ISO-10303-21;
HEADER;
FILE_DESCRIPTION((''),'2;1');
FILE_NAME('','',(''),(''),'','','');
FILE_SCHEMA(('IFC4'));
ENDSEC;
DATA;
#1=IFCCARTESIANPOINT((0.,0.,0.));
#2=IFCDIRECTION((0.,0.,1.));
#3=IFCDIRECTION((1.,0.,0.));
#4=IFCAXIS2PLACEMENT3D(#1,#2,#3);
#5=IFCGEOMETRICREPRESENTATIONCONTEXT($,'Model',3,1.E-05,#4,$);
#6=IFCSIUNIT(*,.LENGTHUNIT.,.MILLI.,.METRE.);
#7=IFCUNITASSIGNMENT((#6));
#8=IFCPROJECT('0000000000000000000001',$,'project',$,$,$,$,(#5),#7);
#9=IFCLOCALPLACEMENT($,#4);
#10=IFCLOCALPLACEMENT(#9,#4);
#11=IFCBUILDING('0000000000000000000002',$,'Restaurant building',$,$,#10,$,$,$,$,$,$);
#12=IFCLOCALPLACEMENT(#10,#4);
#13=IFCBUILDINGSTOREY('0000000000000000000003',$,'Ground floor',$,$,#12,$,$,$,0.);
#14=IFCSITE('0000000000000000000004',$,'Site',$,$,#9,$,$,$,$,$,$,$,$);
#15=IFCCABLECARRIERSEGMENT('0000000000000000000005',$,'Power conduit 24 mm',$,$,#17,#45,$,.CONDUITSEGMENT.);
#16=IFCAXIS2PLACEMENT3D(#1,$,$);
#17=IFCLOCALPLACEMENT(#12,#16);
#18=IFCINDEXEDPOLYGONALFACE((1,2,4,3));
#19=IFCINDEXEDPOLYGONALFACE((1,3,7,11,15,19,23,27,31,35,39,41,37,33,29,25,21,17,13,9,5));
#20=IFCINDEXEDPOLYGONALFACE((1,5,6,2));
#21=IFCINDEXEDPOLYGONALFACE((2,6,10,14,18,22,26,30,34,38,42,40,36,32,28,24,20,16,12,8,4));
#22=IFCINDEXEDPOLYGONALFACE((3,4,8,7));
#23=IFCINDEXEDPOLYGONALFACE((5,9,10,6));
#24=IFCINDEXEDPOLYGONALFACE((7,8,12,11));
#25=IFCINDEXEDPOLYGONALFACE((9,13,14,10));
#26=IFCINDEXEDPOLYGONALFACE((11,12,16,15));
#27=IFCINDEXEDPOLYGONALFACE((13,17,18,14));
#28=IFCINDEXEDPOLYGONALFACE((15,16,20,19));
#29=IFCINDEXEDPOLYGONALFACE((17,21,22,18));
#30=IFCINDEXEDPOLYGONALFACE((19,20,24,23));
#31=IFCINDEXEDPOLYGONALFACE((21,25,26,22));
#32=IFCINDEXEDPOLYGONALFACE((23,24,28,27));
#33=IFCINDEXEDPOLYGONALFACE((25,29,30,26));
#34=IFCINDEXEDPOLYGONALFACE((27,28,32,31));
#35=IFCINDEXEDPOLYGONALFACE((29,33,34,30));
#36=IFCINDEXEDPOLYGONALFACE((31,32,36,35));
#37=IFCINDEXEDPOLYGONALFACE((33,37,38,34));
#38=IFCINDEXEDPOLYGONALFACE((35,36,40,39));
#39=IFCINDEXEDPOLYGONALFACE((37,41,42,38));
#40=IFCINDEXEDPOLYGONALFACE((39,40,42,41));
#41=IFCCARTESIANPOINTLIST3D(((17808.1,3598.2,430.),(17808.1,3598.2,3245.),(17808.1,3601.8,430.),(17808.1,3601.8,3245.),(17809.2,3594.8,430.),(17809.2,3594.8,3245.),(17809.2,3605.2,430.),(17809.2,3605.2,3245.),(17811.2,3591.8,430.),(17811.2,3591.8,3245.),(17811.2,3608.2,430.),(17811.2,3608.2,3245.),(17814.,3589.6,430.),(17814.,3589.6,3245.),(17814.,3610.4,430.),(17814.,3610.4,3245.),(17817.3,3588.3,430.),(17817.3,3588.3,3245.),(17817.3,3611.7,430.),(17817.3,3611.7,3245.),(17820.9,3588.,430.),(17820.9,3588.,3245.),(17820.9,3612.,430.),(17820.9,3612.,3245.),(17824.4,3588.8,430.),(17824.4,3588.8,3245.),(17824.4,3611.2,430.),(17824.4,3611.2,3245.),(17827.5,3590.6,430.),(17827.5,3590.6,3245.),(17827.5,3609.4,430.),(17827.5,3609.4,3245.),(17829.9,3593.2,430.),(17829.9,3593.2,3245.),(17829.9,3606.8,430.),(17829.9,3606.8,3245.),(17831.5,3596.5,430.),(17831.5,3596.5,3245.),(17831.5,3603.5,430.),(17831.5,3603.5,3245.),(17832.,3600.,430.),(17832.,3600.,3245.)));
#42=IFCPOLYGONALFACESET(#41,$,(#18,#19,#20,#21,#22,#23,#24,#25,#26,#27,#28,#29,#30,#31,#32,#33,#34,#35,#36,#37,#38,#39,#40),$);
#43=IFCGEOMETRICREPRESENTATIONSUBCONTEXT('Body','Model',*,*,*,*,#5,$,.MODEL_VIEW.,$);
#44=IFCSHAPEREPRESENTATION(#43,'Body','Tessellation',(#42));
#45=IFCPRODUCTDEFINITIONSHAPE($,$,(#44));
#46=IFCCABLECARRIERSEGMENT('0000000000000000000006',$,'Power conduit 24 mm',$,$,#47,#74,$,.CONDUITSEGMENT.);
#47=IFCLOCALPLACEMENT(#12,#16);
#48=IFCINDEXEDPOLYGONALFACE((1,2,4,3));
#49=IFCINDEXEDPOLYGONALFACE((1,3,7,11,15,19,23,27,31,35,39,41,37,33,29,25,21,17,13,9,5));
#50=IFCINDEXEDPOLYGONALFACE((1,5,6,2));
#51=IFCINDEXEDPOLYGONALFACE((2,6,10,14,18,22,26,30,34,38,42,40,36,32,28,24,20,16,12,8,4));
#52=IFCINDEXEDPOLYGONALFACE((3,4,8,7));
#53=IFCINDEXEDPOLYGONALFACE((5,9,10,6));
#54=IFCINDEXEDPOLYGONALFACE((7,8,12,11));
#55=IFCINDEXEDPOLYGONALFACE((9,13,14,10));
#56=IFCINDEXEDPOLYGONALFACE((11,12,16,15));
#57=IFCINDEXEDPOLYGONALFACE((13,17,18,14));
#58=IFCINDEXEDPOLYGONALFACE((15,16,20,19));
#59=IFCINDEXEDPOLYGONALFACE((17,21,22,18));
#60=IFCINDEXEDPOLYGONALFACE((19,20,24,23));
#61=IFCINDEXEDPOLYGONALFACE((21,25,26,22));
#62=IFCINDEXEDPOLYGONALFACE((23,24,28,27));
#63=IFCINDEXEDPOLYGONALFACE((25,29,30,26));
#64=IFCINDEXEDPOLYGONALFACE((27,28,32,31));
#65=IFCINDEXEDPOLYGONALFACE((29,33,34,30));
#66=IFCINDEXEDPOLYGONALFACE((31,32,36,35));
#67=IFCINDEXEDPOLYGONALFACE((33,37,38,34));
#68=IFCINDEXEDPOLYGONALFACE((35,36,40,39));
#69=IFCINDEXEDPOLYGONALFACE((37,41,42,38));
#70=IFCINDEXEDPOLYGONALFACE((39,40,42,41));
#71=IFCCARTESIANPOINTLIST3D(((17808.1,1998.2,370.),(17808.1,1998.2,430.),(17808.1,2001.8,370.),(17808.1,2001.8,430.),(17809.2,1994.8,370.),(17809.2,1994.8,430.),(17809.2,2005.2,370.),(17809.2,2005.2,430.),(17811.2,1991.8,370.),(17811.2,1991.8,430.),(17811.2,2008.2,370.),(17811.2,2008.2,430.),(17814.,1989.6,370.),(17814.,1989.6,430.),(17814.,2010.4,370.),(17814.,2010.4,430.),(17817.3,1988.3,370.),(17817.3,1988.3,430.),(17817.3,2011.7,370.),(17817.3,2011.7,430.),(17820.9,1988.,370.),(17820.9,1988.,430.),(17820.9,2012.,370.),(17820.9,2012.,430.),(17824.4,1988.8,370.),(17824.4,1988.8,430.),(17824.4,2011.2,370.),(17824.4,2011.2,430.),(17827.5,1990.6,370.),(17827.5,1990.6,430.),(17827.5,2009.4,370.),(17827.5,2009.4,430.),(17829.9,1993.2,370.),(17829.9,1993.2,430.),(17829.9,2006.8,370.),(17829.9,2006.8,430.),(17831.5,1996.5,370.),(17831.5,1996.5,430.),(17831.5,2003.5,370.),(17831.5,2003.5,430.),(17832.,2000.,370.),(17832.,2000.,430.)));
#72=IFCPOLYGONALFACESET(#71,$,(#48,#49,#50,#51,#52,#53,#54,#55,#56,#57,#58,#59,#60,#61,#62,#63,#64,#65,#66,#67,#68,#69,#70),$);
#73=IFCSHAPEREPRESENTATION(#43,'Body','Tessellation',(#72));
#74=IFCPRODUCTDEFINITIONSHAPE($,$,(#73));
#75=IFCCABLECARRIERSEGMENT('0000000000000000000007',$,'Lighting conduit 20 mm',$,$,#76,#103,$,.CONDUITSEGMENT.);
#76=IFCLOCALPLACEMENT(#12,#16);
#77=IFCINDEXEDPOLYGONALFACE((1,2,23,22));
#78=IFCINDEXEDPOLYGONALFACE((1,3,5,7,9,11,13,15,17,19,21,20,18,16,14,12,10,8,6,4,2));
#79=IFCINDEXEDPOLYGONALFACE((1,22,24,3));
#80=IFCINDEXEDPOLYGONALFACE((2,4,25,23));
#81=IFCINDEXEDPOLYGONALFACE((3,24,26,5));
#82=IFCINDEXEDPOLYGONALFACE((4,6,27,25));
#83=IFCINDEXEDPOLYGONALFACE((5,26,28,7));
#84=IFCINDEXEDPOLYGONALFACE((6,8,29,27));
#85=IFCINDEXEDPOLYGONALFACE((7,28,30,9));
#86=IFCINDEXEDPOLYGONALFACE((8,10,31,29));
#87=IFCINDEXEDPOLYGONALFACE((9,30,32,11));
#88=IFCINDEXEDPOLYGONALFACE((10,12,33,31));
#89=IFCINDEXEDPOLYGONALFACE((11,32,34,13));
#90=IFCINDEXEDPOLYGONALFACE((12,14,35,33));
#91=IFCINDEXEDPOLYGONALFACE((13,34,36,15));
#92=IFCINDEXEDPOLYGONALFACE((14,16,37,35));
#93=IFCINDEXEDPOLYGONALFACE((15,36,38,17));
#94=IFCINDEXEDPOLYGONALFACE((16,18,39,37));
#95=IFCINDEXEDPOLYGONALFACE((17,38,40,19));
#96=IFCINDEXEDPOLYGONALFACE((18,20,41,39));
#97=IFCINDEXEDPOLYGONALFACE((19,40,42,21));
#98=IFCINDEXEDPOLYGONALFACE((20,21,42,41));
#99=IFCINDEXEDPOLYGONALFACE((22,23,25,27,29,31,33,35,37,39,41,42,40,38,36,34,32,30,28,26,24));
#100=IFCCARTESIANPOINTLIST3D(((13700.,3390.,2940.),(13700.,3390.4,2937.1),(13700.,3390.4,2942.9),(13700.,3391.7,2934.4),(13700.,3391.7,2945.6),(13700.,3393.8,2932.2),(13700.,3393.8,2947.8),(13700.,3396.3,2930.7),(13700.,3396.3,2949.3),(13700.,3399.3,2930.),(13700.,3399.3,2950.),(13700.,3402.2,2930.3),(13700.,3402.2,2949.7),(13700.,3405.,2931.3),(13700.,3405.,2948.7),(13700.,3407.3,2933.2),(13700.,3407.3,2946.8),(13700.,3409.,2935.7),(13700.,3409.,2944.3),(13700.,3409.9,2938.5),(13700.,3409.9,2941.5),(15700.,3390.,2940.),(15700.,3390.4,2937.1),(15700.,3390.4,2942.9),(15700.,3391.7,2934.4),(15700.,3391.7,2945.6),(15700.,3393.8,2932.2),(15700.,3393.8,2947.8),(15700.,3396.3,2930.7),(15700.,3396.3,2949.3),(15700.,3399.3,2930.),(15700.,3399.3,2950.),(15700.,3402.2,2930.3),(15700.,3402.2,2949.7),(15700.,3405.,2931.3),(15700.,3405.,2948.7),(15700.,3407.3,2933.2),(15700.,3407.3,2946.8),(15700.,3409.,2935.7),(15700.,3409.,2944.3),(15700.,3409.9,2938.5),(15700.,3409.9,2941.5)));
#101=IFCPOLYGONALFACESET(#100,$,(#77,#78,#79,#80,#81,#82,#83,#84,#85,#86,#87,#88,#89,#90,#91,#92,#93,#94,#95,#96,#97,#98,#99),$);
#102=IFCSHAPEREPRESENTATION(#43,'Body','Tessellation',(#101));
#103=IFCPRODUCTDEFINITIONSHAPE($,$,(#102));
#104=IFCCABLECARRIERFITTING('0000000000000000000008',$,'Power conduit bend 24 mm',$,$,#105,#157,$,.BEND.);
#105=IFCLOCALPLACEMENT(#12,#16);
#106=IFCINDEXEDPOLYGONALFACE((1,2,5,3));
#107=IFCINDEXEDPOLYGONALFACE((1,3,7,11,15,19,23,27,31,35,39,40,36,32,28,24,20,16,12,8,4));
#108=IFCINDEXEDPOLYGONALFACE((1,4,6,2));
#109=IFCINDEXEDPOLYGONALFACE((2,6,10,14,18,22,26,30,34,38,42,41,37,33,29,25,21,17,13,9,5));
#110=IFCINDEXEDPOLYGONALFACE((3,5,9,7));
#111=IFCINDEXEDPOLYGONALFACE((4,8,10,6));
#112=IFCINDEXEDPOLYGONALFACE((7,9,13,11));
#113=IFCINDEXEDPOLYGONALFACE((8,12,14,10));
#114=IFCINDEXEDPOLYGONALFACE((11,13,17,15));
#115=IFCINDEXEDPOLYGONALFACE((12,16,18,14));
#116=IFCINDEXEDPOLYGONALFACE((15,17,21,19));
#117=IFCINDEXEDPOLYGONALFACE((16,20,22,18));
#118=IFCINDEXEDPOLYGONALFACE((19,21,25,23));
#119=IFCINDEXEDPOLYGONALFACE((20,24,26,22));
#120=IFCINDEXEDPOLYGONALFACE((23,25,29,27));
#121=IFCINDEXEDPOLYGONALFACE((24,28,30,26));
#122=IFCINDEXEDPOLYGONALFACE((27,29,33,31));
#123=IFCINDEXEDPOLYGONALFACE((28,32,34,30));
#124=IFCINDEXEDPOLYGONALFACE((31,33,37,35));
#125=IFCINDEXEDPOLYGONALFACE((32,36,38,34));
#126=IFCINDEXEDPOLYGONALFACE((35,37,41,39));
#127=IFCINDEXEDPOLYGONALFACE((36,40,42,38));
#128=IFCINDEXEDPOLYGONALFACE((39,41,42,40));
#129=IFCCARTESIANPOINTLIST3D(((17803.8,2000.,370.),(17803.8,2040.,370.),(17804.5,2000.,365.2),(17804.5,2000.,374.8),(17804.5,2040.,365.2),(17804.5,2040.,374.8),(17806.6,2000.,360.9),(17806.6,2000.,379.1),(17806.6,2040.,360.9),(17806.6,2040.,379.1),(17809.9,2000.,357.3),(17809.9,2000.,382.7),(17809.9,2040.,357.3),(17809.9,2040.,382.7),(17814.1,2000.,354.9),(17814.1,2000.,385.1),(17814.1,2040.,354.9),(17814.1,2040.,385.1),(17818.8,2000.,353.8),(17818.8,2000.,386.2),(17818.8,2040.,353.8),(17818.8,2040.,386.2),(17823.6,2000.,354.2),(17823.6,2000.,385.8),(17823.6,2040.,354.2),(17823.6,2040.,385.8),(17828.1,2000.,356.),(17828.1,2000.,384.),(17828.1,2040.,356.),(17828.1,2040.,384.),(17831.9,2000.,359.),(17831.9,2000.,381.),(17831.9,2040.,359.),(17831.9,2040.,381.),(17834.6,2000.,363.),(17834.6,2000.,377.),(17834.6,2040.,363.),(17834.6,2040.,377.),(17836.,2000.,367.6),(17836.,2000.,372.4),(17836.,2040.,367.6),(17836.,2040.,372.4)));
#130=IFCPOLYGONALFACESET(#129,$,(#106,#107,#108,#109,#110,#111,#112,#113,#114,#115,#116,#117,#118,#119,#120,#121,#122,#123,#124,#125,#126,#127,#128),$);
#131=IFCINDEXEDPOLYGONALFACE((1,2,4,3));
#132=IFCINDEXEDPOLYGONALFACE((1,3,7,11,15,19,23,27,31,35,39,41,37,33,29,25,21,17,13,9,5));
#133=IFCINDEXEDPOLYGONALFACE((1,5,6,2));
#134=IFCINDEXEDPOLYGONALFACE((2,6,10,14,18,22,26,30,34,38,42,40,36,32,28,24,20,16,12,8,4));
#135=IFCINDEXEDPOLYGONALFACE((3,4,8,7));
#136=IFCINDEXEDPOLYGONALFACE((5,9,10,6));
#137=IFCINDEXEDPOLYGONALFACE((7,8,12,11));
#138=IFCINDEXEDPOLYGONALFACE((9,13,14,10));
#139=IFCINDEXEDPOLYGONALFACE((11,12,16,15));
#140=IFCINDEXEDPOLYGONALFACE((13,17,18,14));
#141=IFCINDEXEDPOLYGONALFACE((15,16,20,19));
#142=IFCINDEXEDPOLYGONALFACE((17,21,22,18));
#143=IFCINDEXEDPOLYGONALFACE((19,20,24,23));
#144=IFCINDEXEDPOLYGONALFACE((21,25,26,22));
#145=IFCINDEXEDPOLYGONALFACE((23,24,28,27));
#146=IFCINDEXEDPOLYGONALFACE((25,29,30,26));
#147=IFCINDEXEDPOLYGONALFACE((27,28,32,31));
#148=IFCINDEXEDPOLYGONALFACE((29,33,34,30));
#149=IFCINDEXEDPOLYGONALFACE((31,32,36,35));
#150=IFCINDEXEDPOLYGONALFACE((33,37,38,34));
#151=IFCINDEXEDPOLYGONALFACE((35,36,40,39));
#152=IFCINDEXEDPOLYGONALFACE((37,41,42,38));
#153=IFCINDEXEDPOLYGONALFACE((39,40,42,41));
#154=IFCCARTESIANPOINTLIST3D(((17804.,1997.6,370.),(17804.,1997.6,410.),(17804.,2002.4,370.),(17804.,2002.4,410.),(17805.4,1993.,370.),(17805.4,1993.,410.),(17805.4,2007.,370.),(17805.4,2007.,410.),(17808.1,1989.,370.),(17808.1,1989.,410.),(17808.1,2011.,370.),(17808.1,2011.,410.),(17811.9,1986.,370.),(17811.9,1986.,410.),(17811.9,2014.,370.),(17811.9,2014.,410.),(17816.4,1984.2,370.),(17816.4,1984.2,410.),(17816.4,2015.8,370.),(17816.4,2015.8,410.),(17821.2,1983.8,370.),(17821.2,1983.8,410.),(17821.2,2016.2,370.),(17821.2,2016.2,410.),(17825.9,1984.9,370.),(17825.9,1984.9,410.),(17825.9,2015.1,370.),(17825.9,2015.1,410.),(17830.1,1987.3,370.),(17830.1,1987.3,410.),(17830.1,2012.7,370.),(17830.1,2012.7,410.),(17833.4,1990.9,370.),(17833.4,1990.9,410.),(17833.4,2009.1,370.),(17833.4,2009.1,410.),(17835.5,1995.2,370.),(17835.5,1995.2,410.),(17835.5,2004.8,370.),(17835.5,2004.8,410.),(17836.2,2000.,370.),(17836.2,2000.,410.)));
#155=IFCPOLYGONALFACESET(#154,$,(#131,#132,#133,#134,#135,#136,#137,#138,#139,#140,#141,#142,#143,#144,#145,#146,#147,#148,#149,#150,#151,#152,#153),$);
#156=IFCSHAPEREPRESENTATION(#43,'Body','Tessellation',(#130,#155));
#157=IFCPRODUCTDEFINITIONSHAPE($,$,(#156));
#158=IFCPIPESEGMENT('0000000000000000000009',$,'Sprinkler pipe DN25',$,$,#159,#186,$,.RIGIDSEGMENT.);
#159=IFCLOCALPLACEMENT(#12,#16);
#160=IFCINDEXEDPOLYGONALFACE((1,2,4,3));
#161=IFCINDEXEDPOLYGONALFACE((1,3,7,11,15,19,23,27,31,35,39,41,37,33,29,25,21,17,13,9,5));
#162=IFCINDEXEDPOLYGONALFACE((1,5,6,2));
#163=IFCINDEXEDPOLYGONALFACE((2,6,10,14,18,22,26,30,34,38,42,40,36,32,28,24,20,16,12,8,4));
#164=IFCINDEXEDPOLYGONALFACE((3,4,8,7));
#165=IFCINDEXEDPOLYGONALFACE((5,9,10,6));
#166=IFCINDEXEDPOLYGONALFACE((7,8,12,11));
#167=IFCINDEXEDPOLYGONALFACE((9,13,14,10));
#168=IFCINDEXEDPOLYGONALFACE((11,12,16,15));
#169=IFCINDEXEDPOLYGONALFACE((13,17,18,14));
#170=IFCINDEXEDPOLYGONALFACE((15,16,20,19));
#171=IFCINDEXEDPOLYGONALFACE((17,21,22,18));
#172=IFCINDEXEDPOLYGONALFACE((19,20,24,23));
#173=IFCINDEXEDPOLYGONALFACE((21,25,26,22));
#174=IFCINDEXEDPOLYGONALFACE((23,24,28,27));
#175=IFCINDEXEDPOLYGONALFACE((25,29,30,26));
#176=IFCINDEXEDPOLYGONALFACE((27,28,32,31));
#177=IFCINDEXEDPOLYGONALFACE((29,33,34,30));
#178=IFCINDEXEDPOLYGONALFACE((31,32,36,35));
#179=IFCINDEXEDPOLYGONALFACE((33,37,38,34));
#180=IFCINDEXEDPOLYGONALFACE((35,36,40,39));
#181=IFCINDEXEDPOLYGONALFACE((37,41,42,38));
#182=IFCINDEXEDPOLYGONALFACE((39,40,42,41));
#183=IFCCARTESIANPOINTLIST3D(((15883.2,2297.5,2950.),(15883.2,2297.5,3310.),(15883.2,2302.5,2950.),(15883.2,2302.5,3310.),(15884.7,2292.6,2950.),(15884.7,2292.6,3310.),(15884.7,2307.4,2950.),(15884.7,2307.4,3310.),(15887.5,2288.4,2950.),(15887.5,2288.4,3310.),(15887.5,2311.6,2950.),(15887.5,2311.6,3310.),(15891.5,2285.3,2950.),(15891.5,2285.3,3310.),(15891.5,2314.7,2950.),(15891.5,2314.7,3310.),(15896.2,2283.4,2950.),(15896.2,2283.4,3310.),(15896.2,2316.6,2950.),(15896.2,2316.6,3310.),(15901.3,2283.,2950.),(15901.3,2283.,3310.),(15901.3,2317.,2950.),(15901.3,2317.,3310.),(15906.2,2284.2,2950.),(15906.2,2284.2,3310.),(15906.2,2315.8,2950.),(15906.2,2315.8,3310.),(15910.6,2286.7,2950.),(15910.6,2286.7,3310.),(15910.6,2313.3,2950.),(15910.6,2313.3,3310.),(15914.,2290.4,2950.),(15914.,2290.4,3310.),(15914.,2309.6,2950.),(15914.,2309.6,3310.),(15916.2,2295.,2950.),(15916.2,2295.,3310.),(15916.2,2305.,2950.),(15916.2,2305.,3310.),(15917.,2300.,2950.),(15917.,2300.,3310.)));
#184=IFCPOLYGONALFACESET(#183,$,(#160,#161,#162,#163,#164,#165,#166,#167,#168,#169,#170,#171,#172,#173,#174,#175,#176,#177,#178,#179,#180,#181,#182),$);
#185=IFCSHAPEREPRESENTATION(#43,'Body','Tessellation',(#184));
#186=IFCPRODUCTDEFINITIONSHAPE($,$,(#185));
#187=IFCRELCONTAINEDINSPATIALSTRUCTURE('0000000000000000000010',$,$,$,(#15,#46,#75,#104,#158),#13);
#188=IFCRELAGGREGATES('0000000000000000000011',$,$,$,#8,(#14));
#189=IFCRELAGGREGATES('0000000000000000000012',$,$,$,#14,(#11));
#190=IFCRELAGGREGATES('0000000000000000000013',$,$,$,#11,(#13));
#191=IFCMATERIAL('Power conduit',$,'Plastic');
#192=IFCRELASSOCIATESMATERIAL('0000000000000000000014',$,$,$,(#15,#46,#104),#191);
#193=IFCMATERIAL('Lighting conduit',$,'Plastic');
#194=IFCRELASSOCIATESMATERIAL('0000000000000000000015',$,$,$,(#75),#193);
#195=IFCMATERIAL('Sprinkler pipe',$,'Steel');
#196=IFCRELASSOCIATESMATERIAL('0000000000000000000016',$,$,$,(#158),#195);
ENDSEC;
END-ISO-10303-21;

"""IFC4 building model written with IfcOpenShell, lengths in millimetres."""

from ifc_helpers import new_model, si_unit, frame, origin, origin_with_axes, origin_2d, place, context, subcontext, project, spatial, circle, extrude, material, element, save


model = new_model("IFC4")

# Units and contexts
model_context = context("Model", 3, precision=1e-05, world=origin_with_axes())
body_context = subcontext(model_context, "Body", "Model", "MODEL_VIEW")
ifc_project = project(units=[si_unit("LENGTHUNIT", "METRE", prefix="MILLI")], contexts=[model_context])

# Site, building, storey
site_placement = place(None, origin_with_axes())
site = spatial("IfcSite", under=ifc_project, at=site_placement, Name="Site")
building_placement = place(site_placement, origin_with_axes())
building = spatial("IfcBuilding", under=site, at=building_placement, Name="Restaurant building")
storey_placement = place(building_placement, origin_with_axes())
storey = spatial("IfcBuildingStorey", under=building, at=storey_placement, Name="Ground floor", Elevation=0.0)

# Cable carrier segments
ifc_material_1 = material(Name="Power conduit", Category="Plastic")
cable_carrier_segment_1_placement = place(storey_placement, frame((17820.0, 3600.0, 3245.0)))
element("IfcCableCarrierSegment", 1, at=cable_carrier_segment_1_placement, inside=storey, material=ifc_material_1, Name="Power conduit 24 mm", PredefinedType="CONDUITSEGMENT", context=body_context, shape_type="SweptSolid", body=[
    extrude(circle(Radius=12.0, at=origin_2d()), frame((0.0, 0.0, 0.0), z_axis=(0.0, 0.0, -1.0), x_axis=(1.0, 0.0, 0.0)), (0.0, 0.0, 1.0), 2815.0),
])
cable_carrier_segment_2_placement = place(storey_placement, frame((17820.0, 2000.0, 370.0)))
element("IfcCableCarrierSegment", 2, at=cable_carrier_segment_2_placement, inside=storey, material=ifc_material_1, Name="Power conduit 24 mm", PredefinedType="CONDUITSEGMENT", context=body_context, shape_type="SweptSolid", body=[
    extrude(circle(Radius=12.0, at=origin_2d()), origin(), (0.0, 0.0, 1.0), 60.0),
])
ifc_material_2 = material(Name="Lighting conduit", Category="Plastic")
cable_carrier_segment_3_placement = place(storey_placement, frame((15700.0, 3400.0, 2940.0)))
element("IfcCableCarrierSegment", 3, at=cable_carrier_segment_3_placement, inside=storey, material=ifc_material_2, Name="Lighting conduit 20 mm", PredefinedType="CONDUITSEGMENT", context=body_context, shape_type="SweptSolid", body=[
    extrude(circle(Radius=10.0, at=origin_2d()), frame((0.0, 0.0, 0.0), z_axis=(-1.0, 0.0, 0.0), x_axis=(0.0, -1.0, 0.0)), (0.0, 0.0, 1.0), 2000.0),
])

# Cable carrier fitting
cable_carrier_fitting_1_placement = place(storey_placement, frame((17820.0, 2000.0, 370.0)))
element("IfcCableCarrierFitting", 4, at=cable_carrier_fitting_1_placement, inside=storey, material=ifc_material_1, Name="Power conduit bend 24 mm", PredefinedType="BEND", context=body_context, shape_type="SweptSolid", body=[
    extrude(circle(Radius=16.2, at=origin_2d()), frame((0.0, 0.0, 0.0), z_axis=(0.0, 1.0, 0.0), x_axis=(-1.0, 0.0, 0.0)), (0.0, 0.0, 1.0), 40.0),
    extrude(circle(Radius=16.2, at=origin_2d()), origin(), (0.0, 0.0, 1.0), 40.0),
])

# Pipe segment
ifc_material_3 = material(Name="Sprinkler pipe", Category="Steel")
pipe_segment_placement = place(storey_placement, frame((15900.0, 2300.0, 3310.0)))
element("IfcPipeSegment", 5, at=pipe_segment_placement, inside=storey, material=ifc_material_3, Name="Sprinkler pipe DN25", PredefinedType="RIGIDSEGMENT", context=body_context, shape_type="SweptSolid", body=[
    extrude(circle(Radius=17.0, at=origin_2d()), frame((0.0, 0.0, 0.0), z_axis=(0.0, 0.0, -1.0), x_axis=(1.0, 0.0, 0.0)), (0.0, 0.0, 1.0), 360.0),
])

save(model, "model.ifc")
